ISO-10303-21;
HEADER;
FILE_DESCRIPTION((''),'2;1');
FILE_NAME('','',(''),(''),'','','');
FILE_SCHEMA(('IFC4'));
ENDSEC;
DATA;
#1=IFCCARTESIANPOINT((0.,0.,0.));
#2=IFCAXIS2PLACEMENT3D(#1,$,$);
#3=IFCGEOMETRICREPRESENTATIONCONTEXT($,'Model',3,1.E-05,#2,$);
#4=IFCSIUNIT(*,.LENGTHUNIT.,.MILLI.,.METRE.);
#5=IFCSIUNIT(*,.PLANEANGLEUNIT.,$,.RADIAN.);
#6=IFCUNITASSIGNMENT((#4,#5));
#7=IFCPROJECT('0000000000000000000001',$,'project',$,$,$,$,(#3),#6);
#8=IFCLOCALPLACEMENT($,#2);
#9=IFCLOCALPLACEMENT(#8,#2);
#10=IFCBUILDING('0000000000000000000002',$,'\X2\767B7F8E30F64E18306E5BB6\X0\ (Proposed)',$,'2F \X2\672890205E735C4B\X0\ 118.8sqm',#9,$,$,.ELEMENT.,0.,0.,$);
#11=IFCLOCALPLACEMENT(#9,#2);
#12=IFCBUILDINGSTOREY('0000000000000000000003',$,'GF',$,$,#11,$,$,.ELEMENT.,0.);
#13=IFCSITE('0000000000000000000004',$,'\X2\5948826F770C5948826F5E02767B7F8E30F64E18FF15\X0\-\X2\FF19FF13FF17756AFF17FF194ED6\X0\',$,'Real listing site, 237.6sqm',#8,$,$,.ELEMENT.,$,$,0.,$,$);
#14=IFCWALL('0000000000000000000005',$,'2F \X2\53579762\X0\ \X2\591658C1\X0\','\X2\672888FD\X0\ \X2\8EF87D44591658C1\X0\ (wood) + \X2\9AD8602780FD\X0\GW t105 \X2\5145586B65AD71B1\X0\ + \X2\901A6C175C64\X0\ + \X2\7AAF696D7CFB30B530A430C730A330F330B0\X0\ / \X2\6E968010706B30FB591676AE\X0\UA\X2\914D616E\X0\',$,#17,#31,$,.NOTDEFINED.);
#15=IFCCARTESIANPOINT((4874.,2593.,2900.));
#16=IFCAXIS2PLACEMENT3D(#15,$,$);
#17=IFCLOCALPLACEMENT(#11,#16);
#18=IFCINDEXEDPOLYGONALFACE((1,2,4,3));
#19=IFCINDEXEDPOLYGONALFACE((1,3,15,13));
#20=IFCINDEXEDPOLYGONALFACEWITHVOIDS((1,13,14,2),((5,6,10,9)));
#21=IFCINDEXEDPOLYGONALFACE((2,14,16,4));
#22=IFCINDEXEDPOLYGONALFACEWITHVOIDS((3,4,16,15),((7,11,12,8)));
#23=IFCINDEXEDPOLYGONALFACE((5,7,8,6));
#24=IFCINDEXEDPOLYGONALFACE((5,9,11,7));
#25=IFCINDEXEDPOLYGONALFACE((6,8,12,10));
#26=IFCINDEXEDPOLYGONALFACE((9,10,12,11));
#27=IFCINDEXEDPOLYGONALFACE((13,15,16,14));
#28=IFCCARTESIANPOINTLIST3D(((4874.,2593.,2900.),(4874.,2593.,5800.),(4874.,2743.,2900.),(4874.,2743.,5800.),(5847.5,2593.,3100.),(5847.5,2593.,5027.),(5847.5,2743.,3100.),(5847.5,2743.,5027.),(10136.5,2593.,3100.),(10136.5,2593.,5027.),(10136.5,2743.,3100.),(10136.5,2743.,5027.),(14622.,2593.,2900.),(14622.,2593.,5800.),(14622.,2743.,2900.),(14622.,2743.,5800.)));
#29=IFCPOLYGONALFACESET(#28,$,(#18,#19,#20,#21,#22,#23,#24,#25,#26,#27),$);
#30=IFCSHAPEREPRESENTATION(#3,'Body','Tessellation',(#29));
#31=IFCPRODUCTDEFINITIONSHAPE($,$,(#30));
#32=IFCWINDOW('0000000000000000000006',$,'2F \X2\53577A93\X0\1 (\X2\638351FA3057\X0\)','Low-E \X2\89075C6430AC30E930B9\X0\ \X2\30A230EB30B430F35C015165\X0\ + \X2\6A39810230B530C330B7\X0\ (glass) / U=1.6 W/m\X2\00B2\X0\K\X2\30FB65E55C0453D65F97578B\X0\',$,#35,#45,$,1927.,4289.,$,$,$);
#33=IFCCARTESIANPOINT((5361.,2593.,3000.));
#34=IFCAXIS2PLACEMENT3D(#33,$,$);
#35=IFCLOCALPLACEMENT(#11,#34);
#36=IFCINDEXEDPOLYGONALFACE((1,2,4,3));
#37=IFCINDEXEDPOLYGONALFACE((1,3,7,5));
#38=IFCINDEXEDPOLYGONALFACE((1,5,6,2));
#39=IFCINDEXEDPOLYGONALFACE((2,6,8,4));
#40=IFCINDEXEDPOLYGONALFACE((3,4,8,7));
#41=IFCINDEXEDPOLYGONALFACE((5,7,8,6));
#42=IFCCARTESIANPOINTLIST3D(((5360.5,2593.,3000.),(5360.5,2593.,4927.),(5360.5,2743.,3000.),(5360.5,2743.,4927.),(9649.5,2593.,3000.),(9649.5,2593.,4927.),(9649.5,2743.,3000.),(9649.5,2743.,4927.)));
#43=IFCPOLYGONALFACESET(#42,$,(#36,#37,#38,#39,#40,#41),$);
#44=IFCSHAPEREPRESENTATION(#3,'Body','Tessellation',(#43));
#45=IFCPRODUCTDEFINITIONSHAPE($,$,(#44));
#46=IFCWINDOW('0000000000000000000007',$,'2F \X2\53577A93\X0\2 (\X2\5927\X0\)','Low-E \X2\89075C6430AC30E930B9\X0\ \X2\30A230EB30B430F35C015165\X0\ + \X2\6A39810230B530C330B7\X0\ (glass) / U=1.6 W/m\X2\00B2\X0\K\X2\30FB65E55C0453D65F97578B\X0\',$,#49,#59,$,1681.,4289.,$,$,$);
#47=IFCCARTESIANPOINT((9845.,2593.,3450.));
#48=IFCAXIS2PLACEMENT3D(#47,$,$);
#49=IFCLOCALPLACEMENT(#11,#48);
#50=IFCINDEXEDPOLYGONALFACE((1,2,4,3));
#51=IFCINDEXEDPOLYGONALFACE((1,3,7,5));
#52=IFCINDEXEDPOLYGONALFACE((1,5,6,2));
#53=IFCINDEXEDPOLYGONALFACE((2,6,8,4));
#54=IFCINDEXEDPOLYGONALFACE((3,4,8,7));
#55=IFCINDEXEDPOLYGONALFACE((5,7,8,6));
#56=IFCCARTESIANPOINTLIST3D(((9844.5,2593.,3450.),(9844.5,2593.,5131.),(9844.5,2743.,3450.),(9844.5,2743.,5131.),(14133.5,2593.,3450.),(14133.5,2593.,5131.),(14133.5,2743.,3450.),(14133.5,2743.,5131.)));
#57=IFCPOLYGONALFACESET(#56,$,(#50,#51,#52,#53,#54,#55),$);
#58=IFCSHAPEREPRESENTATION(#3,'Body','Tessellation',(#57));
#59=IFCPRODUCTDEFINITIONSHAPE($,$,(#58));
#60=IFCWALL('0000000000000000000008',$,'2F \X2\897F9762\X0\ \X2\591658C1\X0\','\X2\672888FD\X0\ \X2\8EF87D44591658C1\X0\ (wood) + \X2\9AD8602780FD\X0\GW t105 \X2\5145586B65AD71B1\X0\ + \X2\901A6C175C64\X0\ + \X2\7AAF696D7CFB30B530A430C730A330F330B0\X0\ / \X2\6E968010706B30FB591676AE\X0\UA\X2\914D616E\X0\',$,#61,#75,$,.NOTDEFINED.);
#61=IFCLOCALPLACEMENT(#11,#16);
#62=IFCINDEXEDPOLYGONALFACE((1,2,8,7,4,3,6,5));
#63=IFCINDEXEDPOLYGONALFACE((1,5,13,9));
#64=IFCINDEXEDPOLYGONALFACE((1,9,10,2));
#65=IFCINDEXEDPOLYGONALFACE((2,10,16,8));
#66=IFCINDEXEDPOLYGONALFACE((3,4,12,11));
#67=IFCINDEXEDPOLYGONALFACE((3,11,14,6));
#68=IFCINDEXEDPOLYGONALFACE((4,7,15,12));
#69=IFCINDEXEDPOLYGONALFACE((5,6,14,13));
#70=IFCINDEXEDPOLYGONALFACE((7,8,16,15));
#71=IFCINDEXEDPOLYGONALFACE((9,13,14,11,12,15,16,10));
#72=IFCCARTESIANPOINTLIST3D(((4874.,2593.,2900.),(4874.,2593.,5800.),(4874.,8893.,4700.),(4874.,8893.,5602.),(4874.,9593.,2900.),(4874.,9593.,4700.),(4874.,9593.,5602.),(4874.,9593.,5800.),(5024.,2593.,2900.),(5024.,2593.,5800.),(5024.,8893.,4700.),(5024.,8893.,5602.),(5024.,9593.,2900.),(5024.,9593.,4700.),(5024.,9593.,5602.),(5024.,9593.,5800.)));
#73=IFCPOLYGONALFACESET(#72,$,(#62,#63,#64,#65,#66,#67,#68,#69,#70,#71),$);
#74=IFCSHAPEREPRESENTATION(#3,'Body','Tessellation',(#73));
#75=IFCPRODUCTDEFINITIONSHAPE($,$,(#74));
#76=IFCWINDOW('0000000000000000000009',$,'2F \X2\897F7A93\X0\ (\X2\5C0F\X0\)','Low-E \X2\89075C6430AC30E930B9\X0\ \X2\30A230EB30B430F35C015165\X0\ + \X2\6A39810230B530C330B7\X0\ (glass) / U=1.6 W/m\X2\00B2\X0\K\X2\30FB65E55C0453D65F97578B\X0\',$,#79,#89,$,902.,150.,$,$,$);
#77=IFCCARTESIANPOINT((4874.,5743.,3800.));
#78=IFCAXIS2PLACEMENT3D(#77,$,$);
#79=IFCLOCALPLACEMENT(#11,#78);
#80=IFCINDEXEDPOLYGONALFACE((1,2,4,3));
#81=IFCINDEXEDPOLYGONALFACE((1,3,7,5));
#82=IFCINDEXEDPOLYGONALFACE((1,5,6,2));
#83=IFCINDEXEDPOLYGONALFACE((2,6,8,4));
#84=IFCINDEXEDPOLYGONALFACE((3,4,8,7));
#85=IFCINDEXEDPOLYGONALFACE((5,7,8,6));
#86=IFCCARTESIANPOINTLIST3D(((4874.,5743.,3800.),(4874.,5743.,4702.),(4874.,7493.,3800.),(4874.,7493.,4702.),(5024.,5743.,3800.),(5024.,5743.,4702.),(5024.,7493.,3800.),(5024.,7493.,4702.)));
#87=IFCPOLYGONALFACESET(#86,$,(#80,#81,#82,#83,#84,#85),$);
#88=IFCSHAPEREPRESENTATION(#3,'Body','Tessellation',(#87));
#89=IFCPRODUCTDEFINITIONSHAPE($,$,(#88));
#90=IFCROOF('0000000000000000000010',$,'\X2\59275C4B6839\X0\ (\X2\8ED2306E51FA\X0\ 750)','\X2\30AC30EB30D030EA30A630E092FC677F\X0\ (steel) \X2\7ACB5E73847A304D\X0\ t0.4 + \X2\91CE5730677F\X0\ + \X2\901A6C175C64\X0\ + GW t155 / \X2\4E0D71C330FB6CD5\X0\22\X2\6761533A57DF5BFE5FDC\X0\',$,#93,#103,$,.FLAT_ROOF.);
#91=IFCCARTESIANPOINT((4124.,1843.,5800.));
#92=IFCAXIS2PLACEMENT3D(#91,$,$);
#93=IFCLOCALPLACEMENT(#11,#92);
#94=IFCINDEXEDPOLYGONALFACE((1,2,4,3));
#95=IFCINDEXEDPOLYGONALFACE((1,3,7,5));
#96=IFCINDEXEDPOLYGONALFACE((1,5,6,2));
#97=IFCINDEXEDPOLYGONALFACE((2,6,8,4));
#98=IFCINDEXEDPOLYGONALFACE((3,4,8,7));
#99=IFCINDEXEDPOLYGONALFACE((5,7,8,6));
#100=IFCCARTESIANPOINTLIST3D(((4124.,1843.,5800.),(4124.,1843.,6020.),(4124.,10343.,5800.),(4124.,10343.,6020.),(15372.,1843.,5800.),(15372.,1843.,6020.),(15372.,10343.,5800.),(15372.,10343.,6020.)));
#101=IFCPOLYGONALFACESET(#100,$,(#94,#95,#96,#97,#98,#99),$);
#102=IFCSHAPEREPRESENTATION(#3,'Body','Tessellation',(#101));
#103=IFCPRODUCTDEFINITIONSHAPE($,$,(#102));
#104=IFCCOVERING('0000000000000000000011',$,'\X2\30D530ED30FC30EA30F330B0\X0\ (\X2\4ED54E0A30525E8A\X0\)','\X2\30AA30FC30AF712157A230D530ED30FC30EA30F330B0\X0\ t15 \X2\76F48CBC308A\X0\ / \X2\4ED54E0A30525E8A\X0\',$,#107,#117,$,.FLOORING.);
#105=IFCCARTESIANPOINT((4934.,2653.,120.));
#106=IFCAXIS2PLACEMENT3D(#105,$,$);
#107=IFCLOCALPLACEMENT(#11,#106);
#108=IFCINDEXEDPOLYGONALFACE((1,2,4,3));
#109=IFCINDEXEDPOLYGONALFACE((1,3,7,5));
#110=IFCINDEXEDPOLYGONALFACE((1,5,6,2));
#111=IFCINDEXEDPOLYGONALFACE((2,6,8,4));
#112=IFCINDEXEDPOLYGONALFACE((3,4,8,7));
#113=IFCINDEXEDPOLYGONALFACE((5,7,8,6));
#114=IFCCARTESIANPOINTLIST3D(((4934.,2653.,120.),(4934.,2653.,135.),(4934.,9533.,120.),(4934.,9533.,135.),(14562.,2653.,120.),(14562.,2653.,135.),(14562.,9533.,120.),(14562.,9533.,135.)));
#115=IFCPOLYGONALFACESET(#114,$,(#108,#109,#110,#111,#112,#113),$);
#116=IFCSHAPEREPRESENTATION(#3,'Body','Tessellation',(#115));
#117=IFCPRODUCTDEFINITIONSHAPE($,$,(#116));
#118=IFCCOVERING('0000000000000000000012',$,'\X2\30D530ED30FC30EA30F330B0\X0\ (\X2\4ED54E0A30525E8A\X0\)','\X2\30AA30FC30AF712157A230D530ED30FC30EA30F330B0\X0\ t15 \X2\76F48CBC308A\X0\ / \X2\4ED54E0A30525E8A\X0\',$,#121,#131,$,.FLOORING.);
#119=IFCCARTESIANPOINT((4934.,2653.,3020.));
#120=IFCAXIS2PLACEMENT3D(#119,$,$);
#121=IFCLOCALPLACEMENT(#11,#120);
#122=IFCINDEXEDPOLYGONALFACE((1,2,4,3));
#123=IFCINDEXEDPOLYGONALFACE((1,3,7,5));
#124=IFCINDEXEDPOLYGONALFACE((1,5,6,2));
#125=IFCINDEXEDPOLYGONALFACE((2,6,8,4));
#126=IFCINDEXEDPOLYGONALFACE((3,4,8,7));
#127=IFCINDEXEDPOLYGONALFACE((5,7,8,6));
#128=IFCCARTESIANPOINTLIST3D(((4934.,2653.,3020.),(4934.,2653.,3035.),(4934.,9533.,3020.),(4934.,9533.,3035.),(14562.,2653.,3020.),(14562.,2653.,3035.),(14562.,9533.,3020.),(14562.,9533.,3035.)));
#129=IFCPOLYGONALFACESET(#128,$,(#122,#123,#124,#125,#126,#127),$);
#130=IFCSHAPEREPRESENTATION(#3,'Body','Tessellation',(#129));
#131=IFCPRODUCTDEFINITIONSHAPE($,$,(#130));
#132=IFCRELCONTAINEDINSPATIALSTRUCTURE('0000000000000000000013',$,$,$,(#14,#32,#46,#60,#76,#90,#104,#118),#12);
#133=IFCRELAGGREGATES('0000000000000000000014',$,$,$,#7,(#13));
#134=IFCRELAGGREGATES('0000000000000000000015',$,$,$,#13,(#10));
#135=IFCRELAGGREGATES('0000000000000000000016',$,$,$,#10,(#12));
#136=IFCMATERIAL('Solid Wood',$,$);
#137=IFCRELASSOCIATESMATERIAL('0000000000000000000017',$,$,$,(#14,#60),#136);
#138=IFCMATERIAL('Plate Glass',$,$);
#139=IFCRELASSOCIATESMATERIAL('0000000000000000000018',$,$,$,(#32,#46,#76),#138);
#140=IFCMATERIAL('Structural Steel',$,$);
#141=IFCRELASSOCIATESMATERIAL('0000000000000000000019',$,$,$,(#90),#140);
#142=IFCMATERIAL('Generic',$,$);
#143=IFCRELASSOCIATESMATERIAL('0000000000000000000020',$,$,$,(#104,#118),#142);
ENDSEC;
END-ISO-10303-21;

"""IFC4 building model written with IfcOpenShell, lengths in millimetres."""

from ifc_helpers import new_model, si_unit, frame, frame_2d, origin, place, context, project, spatial, rectangle, extrude, material, element, fill, save


model = new_model("IFC4")

# Units and contexts
model_context = context("Model", 3, precision=1e-05, world=origin())
ifc_project = project(units=[si_unit("LENGTHUNIT", "METRE", prefix="MILLI"), si_unit("PLANEANGLEUNIT", "RADIAN")], contexts=[model_context])

# Site, building, storey
site_placement = place(None, origin())
site = spatial("IfcSite", under=ifc_project, at=site_placement, Name="奈良県奈良市登美ヶ丘５-９３７番７９他", ObjectType="Real listing site, 237.6sqm", CompositionType="ELEMENT", RefElevation=0.0)
building_placement = place(site_placement, origin())
building = spatial("IfcBuilding", under=site, at=building_placement, Name="登美ヶ丘の家 (Proposed)", ObjectType="2F 木造平屋 118.8sqm", CompositionType="ELEMENT", ElevationOfRefHeight=0.0, ElevationOfTerrain=0.0)
storey_placement = place(building_placement, origin())
storey = spatial("IfcBuildingStorey", under=building, at=storey_placement, Name="GF", CompositionType="ELEMENT", Elevation=0.0)

# Shared definitions
ifc_material_1 = material(Name="Solid Wood")

# Shared definitions
ifc_material_2 = material(Name="Plate Glass")

# Wall, openings, windows
wall_1_placement = place(storey_placement, frame((4874.0, 2593.0, 2900.0)))
wall_1 = element("IfcWall", 1, at=wall_1_placement, inside=storey, material=ifc_material_1, Name="2F 南面 外壁", Description="木製 軸組外壁 (wood) + 高性能GW t105 充填断熱 + 通気層 + 窯業系サイディング / 準耐火・外皮UA配慮", PredefinedType="NOTDEFINED", context=model_context, shape_type="SweptSolid", body=[
    extrude(rectangle(XDim=9748.0, YDim=150.0, at=frame_2d((4874.0, 75.0))), frame((4874.0, 2593.0, 2900.0)), (0.0, 0.0, 1.0), 2900.0),
])
opening_1_placement = place(storey_placement, frame((5361.0, 2593.0, 3000.0)))
opening_1 = element("IfcOpeningElement", 2, at=opening_1_placement, cuts=wall_1, PredefinedType="NOTDEFINED", context=model_context, shape_type="SweptSolid", body=[
    extrude(rectangle(XDim=4289.0, YDim=150.0, at=frame_2d((2144.0, 75.0))), frame((5361.0, 2593.0, 3000.0)), (0.0, 0.0, 1.0), 1927.0),
])
opening_2_placement = place(storey_placement, frame((9845.0, 2593.0, 3450.0)))
opening_2 = element("IfcOpeningElement", 3, at=opening_2_placement, cuts=wall_1, PredefinedType="NOTDEFINED", context=model_context, shape_type="SweptSolid", body=[
    extrude(rectangle(XDim=4289.0, YDim=150.0, at=frame_2d((2144.0, 75.0))), frame((9845.0, 2593.0, 3450.0)), (0.0, 0.0, 1.0), 1681.0),
])
window_1_placement = place(storey_placement, frame((5361.0, 2593.0, 3000.0)))
window_1 = element("IfcWindow", 4, at=window_1_placement, inside=storey, material=ifc_material_2, Name="2F 南窓1 (掃出し)", Description="Low-E 複層ガラス アルゴン封入 + 樹脂サッシ (glass) / U=1.6 W/m²K・日射取得型", OverallHeight=1927.0, OverallWidth=4289.0, context=model_context, shape_type="SweptSolid", body=[
    extrude(rectangle(XDim=4289.0, YDim=150.0, at=frame_2d((2144.0, 75.0))), frame((5361.0, 2593.0, 3000.0)), (0.0, 0.0, 1.0), 1927.0),
])
fill(opening_1, window_1)
window_2_placement = place(storey_placement, frame((9845.0, 2593.0, 3450.0)))
window_2 = element("IfcWindow", 5, at=window_2_placement, inside=storey, material=ifc_material_2, Name="2F 南窓2 (大)", Description="Low-E 複層ガラス アルゴン封入 + 樹脂サッシ (glass) / U=1.6 W/m²K・日射取得型", OverallHeight=1681.0, OverallWidth=4289.0, context=model_context, shape_type="SweptSolid", body=[
    extrude(rectangle(XDim=4289.0, YDim=150.0, at=frame_2d((2144.0, 75.0))), frame((9845.0, 2593.0, 3450.0)), (0.0, 0.0, 1.0), 1681.0),
])
fill(opening_2, window_2)

# Wall, opening, window
wall_2_placement = place(storey_placement, frame((4874.0, 2593.0, 2900.0)))
wall_2 = element("IfcWall", 6, at=wall_2_placement, inside=storey, material=ifc_material_1, Name="2F 西面 外壁", Description="木製 軸組外壁 (wood) + 高性能GW t105 充填断熱 + 通気層 + 窯業系サイディング / 準耐火・外皮UA配慮", PredefinedType="NOTDEFINED", context=model_context, shape_type="SweptSolid", body=[
    extrude(rectangle(XDim=150.0, YDim=7000.0, at=frame_2d((75.0, 3500.0))), frame((4874.0, 2593.0, 2900.0)), (0.0, 0.0, 1.0), 2900.0),
])
opening_3_placement = place(storey_placement, frame((4874.0, 5743.0, 3800.0)))
opening_3 = element("IfcOpeningElement", 7, at=opening_3_placement, cuts=wall_2, PredefinedType="NOTDEFINED", context=model_context, shape_type="SweptSolid", body=[
    extrude(rectangle(XDim=150.0, YDim=1750.0, at=frame_2d((75.0, 875.0))), frame((4874.0, 5743.0, 3800.0)), (0.0, 0.0, 1.0), 902.0),
])
window_3_placement = place(storey_placement, frame((4874.0, 5743.0, 3800.0)))
window_3 = element("IfcWindow", 8, at=window_3_placement, inside=storey, material=ifc_material_2, Name="2F 西窓 (小)", Description="Low-E 複層ガラス アルゴン封入 + 樹脂サッシ (glass) / U=1.6 W/m²K・日射取得型", OverallHeight=902.0, OverallWidth=150.0, context=model_context, shape_type="SweptSolid", body=[
    extrude(rectangle(XDim=150.0, YDim=1750.0, at=frame_2d((75.0, 875.0))), frame((4874.0, 5743.0, 3800.0)), (0.0, 0.0, 1.0), 902.0),
])
fill(opening_3, window_3)

# Roof
ifc_material_3 = material(Name="Structural Steel")
roof_placement = place(storey_placement, frame((4124.0, 1843.0, 5800.0)))
element("IfcRoof", 9, at=roof_placement, inside=storey, material=ifc_material_3, Name="大屋根 (軒の出 750)", Description="ガルバリウム鋼板 (steel) 立平葺き t0.4 + 野地板 + 通気層 + GW t155 / 不燃・法22条区域対応", PredefinedType="FLAT_ROOF", context=model_context, shape_type="SweptSolid", body=[
    extrude(rectangle(XDim=11248.0, YDim=8500.0, at=frame_2d((5624.0, 4250.0))), frame((4124.0, 1843.0, 5800.0)), (0.0, 0.0, 1.0), 220.0),
])

# Coverings
ifc_material_4 = material(Name="Generic")
covering_1_placement = place(storey_placement, frame((4934.0, 2653.0, 120.0)))
element("IfcCovering", 10, at=covering_1_placement, inside=storey, material=ifc_material_4, Name="フローリング (仕上げ床)", Description="オーク無垢フローリング t15 直貼り / 仕上げ床", PredefinedType="FLOORING", context=model_context, shape_type="SweptSolid", body=[
    extrude(rectangle(XDim=9628.0, YDim=6880.0, at=frame_2d((4814.0, 3440.0))), frame((4934.0, 2653.0, 120.0)), (0.0, 0.0, 1.0), 15.0),
])
covering_2_placement = place(storey_placement, frame((4934.0, 2653.0, 3020.0)))
element("IfcCovering", 11, at=covering_2_placement, inside=storey, material=ifc_material_4, Name="フローリング (仕上げ床)", Description="オーク無垢フローリング t15 直貼り / 仕上げ床", PredefinedType="FLOORING", context=model_context, shape_type="SweptSolid", body=[
    extrude(rectangle(XDim=9628.0, YDim=6880.0, at=frame_2d((4814.0, 3440.0))), frame((4934.0, 2653.0, 3020.0)), (0.0, 0.0, 1.0), 15.0),
])

save(model, "model.ifc")
